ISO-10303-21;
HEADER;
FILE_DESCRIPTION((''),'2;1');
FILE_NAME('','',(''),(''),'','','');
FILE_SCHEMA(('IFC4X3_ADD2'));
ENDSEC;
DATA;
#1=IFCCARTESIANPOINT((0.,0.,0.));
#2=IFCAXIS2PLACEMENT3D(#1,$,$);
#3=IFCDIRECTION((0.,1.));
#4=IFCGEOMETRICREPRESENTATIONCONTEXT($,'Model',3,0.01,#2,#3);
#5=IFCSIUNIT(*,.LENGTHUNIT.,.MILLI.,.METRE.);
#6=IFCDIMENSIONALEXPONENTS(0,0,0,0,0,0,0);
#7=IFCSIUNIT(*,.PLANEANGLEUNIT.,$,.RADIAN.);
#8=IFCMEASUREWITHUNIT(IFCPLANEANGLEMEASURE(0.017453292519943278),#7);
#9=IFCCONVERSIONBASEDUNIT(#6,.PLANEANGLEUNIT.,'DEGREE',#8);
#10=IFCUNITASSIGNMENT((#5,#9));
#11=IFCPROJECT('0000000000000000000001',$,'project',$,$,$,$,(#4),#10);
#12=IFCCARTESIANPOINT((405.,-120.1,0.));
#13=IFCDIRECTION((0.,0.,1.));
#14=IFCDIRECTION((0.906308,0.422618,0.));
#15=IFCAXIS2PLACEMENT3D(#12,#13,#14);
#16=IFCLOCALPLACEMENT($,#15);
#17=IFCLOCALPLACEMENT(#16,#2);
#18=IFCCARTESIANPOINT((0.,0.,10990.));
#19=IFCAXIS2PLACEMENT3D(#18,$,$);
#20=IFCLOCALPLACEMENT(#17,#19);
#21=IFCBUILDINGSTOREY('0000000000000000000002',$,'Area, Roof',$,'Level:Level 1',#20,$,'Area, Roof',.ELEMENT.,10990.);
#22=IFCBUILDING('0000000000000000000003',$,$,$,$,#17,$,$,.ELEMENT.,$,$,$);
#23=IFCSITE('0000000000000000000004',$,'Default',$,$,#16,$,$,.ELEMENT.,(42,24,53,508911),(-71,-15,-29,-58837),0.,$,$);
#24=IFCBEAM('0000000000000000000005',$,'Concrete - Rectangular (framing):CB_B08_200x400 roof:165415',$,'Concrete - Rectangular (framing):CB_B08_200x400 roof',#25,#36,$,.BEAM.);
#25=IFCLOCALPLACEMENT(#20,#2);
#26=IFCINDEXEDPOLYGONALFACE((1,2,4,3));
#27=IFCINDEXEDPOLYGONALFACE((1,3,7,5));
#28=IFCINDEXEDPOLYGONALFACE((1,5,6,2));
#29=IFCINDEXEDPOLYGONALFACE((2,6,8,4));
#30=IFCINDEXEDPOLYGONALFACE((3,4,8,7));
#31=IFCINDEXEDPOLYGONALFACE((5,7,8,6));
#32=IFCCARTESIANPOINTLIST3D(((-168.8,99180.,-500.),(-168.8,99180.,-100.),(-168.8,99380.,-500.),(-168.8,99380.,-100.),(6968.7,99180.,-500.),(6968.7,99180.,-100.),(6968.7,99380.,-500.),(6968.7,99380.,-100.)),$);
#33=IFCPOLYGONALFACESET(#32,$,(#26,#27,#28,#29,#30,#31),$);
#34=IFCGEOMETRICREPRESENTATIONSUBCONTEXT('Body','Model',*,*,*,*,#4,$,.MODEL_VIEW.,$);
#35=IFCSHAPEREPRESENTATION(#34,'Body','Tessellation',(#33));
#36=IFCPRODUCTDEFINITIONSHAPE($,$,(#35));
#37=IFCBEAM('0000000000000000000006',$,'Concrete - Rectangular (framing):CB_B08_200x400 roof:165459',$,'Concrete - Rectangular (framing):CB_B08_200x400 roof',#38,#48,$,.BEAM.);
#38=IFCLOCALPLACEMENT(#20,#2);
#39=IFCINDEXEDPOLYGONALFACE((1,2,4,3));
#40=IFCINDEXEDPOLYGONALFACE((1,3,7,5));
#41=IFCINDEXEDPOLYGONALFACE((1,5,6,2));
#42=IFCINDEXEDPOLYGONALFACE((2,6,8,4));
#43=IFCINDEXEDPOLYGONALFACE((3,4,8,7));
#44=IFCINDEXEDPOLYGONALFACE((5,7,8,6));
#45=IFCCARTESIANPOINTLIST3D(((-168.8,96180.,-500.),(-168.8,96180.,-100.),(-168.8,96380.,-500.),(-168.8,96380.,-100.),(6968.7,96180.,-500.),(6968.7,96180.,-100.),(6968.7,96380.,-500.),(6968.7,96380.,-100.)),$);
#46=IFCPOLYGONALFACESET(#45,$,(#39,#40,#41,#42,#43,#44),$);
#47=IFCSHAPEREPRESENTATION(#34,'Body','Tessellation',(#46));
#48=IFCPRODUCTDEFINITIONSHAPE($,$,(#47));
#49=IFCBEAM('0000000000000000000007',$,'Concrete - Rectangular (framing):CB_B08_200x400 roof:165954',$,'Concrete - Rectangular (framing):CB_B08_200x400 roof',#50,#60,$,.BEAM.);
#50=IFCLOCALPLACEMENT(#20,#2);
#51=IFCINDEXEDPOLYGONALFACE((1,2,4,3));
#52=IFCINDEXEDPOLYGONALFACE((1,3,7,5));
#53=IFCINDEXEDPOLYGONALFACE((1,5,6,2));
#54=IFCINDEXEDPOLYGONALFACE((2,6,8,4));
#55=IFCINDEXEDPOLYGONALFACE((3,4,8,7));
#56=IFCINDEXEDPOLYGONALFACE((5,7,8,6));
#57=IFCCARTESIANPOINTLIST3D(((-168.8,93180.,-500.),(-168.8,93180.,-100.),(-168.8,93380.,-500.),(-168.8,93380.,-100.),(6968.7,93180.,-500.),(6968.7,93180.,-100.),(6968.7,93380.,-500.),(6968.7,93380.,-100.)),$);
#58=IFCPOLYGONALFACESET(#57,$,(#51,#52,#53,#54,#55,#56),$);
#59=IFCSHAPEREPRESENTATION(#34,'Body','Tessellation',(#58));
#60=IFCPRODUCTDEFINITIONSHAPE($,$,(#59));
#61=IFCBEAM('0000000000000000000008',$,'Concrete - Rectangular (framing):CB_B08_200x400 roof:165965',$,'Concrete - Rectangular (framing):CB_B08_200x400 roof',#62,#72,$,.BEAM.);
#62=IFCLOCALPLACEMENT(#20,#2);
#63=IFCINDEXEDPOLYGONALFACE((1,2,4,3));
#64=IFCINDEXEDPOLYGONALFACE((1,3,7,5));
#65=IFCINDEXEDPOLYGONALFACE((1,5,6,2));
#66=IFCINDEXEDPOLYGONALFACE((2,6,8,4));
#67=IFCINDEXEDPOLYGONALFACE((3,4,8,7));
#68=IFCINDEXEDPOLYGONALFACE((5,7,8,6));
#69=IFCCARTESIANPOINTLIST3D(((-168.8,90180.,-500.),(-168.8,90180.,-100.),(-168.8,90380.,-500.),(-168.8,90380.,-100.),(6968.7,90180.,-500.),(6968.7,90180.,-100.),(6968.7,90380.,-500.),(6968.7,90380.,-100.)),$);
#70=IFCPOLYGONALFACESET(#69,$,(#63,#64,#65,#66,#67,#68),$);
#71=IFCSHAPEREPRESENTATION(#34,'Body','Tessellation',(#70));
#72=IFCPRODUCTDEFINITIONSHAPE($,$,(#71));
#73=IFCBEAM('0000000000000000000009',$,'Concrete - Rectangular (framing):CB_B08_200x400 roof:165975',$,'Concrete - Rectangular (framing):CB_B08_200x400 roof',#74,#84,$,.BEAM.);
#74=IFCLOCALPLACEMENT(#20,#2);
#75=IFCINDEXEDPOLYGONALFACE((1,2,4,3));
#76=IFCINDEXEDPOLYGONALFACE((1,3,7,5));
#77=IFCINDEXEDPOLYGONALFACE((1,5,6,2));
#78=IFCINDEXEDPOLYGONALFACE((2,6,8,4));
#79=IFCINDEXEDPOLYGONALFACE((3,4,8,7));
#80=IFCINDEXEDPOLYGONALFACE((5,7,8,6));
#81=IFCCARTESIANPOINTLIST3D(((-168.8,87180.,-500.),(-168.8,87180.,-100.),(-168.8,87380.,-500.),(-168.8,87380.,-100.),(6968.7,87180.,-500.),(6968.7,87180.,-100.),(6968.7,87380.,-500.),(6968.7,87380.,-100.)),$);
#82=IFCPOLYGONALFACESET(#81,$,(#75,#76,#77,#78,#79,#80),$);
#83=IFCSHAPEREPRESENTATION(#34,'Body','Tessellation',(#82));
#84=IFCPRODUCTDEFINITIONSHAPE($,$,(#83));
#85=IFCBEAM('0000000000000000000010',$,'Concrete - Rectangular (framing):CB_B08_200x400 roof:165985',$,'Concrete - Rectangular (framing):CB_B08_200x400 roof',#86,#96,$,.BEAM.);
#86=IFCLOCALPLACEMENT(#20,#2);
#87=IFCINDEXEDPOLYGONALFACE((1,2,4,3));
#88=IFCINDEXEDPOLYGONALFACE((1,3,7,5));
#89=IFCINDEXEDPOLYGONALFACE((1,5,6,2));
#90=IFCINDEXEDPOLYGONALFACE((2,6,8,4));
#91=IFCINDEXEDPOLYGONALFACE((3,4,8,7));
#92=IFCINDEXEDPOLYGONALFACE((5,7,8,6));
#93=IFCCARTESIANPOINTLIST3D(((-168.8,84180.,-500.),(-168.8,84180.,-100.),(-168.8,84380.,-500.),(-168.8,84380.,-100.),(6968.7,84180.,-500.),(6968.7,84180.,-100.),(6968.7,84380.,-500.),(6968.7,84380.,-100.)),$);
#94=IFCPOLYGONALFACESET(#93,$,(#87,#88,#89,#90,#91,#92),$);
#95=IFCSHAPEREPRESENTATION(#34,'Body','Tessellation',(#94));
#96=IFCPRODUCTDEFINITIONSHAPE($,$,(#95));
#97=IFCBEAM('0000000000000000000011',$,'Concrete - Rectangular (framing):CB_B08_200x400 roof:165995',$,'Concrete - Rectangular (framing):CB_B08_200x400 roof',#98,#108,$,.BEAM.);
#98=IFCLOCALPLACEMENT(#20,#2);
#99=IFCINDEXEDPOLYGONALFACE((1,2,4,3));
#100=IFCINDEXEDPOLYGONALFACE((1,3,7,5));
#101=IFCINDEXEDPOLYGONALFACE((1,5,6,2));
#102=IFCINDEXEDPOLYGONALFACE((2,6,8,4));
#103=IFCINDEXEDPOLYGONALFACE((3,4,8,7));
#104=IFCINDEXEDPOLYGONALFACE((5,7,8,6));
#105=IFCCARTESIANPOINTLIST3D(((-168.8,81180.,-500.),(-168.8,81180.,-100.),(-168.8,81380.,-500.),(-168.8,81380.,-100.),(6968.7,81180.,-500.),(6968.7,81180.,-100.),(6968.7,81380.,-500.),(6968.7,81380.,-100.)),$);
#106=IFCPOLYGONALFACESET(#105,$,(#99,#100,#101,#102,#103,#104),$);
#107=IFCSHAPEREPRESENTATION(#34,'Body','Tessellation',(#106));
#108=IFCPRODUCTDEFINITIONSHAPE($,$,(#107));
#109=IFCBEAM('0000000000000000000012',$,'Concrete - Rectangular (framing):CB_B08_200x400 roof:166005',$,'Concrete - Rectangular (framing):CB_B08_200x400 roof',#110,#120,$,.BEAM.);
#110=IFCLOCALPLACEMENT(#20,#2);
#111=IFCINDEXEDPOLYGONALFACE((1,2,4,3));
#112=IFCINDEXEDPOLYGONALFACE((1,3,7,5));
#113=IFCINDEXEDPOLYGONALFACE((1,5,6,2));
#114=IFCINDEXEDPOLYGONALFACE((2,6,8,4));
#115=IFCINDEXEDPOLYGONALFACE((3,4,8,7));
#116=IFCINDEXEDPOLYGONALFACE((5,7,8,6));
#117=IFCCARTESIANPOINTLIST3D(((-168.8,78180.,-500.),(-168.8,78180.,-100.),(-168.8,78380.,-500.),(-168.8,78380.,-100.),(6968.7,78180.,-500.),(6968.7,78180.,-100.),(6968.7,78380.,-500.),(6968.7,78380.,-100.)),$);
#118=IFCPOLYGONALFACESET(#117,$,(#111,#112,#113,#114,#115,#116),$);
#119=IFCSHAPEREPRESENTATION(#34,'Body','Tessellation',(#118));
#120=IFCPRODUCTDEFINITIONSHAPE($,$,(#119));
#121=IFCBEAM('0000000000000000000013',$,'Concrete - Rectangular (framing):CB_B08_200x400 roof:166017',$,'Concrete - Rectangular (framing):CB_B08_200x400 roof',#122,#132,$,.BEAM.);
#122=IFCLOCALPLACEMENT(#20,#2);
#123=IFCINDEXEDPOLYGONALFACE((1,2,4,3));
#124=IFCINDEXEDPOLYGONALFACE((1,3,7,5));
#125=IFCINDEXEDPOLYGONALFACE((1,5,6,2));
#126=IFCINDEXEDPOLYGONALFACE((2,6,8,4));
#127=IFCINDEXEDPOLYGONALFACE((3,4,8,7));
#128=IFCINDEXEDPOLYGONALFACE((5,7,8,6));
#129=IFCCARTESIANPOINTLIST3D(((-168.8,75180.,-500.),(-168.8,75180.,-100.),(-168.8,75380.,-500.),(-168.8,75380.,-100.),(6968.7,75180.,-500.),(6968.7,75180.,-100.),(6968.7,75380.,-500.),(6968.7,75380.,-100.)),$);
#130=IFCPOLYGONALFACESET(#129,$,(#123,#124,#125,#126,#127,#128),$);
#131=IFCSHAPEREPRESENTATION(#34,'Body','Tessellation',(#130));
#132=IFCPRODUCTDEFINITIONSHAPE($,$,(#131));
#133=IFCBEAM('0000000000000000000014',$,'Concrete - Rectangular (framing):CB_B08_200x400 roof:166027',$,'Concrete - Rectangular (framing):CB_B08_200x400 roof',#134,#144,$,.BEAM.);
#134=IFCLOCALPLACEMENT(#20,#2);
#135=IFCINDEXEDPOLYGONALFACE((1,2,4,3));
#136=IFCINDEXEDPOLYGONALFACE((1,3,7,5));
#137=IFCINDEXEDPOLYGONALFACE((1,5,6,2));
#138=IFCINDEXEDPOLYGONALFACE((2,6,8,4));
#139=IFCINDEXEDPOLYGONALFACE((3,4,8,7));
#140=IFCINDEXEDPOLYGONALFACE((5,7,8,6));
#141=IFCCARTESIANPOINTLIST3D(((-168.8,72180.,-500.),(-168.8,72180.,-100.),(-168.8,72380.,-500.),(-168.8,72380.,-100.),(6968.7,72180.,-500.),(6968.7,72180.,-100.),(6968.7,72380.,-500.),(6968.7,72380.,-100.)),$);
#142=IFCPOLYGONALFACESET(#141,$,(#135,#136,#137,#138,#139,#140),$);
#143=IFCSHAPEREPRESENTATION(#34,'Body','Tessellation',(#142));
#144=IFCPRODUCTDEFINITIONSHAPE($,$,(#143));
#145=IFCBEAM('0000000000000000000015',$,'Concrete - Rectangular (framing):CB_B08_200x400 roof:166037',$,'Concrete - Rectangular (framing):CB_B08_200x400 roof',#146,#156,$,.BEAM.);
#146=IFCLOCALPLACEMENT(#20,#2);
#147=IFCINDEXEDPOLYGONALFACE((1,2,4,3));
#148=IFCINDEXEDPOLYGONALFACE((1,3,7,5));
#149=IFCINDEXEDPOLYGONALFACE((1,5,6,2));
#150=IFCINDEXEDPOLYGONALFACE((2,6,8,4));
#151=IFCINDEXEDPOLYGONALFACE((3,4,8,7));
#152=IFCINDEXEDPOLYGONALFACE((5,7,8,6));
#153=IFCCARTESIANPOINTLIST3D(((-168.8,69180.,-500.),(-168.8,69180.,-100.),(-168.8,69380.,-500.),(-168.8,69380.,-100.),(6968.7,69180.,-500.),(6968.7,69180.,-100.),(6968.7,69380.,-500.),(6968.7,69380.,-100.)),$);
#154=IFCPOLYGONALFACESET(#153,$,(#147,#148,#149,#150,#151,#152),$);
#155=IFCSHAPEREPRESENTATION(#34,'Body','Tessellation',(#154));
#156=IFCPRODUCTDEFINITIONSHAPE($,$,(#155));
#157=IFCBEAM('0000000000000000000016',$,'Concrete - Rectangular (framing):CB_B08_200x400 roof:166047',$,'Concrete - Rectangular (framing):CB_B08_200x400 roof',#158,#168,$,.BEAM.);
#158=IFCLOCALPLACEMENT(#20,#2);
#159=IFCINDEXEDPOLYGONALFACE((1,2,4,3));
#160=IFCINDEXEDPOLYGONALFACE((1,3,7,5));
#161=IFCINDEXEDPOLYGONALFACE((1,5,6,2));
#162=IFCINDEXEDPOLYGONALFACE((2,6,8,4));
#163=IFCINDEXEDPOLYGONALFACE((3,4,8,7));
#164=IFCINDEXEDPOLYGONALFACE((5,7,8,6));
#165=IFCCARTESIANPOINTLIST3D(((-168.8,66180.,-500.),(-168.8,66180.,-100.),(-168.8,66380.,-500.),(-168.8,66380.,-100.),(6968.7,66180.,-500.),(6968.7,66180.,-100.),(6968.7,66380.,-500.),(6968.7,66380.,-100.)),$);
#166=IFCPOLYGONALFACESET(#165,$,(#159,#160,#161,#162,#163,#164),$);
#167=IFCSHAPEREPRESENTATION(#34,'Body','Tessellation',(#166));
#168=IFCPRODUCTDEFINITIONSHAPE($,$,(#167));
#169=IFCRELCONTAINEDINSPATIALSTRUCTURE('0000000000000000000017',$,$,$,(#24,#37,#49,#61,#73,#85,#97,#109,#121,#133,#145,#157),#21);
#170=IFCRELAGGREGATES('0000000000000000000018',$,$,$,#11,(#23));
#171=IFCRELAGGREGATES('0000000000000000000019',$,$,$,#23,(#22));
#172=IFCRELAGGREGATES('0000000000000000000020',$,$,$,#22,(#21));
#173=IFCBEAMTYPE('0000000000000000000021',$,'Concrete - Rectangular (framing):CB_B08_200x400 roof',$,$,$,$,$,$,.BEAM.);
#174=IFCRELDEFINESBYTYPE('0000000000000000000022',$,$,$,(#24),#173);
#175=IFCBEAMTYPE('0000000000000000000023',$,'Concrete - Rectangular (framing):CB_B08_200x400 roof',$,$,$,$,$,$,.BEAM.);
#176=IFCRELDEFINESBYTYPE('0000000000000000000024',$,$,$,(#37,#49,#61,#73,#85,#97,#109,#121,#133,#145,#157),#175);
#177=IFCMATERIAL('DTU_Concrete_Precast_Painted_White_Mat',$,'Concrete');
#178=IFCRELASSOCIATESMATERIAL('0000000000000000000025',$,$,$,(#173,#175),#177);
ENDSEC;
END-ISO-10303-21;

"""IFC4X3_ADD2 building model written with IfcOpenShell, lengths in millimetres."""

from ifc_helpers import new_model, entity, si_unit, converted_unit, direction, frame, origin, origin_2d_with_axis, place, context, subcontext, project, spatial, rectangle, extrude, source, transform, mapped, material, material_profile, profile_set, type_object, type_shapes, element, save


model = new_model("IFC4X3_ADD2")

# Units and contexts
model_context = context("Model", 3, precision=0.01, world=origin(), true_north=direction((0.0, 1.0)))
body_context = subcontext(model_context, "Body", "Model", "MODEL_VIEW")
ifc_project = project(units=[si_unit("LENGTHUNIT", "METRE", prefix="MILLI"), converted_unit("PLANEANGLEUNIT", "DEGREE", entity("IfcPlaneAngleMeasure", 0.017453292519943278), si_unit("PLANEANGLEUNIT", "RADIAN"), dimensions=[0, 0, 0, 0, 0, 0, 0])], contexts=[model_context])

# Site, building, storey
site_placement = place(None, frame((405.0, -120.1, 0.0), z_axis=(0.0, 0.0, 1.0), x_axis=(0.906308, 0.422618, 0.0)))
site = spatial("IfcSite", under=ifc_project, at=site_placement, Name="Default", CompositionType="ELEMENT", RefLatitude=(42, 24, 53, 508911), RefLongitude=(-71, -15, -29, -58837), RefElevation=0.0)
building_placement = place(site_placement, origin())
building = spatial("IfcBuilding", under=site, at=building_placement, CompositionType="ELEMENT")
storey_placement = place(building_placement, frame((0.0, 0.0, 10990.0)))
storey = spatial("IfcBuildingStorey", under=building, at=storey_placement, Name="Area, Roof", ObjectType="Level:Level 1", LongName="Area, Roof", CompositionType="ELEMENT", Elevation=10990.0)

# Beams
ifc_material = material(Name="DTU_Concrete_Precast_Painted_White_Mat", Category="Concrete")
ifc_material_profile = material_profile(ifc_material, rectangle(XDim=7137.5, YDim=200.0, at=origin_2d_with_axis()), Name="CB_B08_200x400 roof")
ifc_profile_set = profile_set([ifc_material_profile], Name="CB_B08_200x400 roof")
beam_type_1 = type_object("IfcBeamType", Name="Concrete - Rectangular (framing):CB_B08_200x400 roof", PredefinedType="BEAM", material=ifc_profile_set)
shared_shape_1 = source(origin(), body_context, "Body", "SweptSolid", [
    extrude(rectangle(XDim=7137.5, YDim=200.0, at=origin_2d_with_axis()), frame((6.3, 0.0, -200.0), z_axis=(0.0, 0.0, 1.0), x_axis=(-1.0, 0.0, 0.0)), (0.0, 0.0, 1.0), 400.0),
])
type_shapes(beam_type_1, [shared_shape_1])
beam_placement = place(storey_placement, frame((3406.2, 99280.0, -300.0), z_axis=(0.0, 0.0, 1.0), x_axis=(-1.0, 0.0, 0.0)))
element("IfcBeam", 1, at=beam_placement, inside=storey, type_object=beam_type_1, Name="Concrete - Rectangular (framing):CB_B08_200x400 roof:165415", ObjectType="Concrete - Rectangular (framing):CB_B08_200x400 roof", PredefinedType="BEAM", context=body_context, shape_type="MappedRepresentation", body=[
    mapped(shared_shape_1, transform((0.0, 0.0, 0.0), scale=1.0)),
])
beam_type_2 = type_object("IfcBeamType", Name="Concrete - Rectangular (framing):CB_B08_200x400 roof", PredefinedType="BEAM", material=ifc_profile_set)
shared_shape_2 = source(origin(), body_context, "Body", "SweptSolid", [
    extrude(rectangle(XDim=7137.5, YDim=200.0, at=origin_2d_with_axis()), frame((6.3, 0.0, -200.0), z_axis=(0.0, 0.0, 1.0), x_axis=(-1.0, 0.0, 0.0)), (0.0, 0.0, 1.0), 400.0),
])
type_shapes(beam_type_2, [shared_shape_2])
for number, where, z_axis, x_axis, name in (
    (2, (3406.2, 96280.0, -300.0), (0.0, 0.0, 1.0), (-1.0, 0.0, 0.0), "Concrete - Rectangular (framing):CB_B08_200x400 roof:165459"),
    (3, (3406.2, 93280.0, -300.0), (0.0, 0.0, 1.0), (-1.0, 0.0, 0.0), "Concrete - Rectangular (framing):CB_B08_200x400 roof:165954"),
    (4, (3406.2, 90280.0, -300.0), (0.0, 0.0, 1.0), (-1.0, 0.0, 0.0), "Concrete - Rectangular (framing):CB_B08_200x400 roof:165965"),
    (5, (3406.2, 87280.0, -300.0), (0.0, 0.0, 1.0), (-1.0, 0.0, 0.0), "Concrete - Rectangular (framing):CB_B08_200x400 roof:165975"),
    (6, (3406.2, 84280.0, -300.0), (0.0, 0.0, 1.0), (-1.0, 0.0, 0.0), "Concrete - Rectangular (framing):CB_B08_200x400 roof:165985"),
    (7, (3406.2, 81280.0, -300.0), (0.0, 0.0, 1.0), (-1.0, 0.0, 0.0), "Concrete - Rectangular (framing):CB_B08_200x400 roof:165995"),
    (8, (3406.2, 78280.0, -300.0), (0.0, 0.0, 1.0), (-1.0, 0.0, 0.0), "Concrete - Rectangular (framing):CB_B08_200x400 roof:166005"),
    (9, (3406.2, 75280.0, -300.0), (0.0, 0.0, 1.0), (-1.0, 0.0, 0.0), "Concrete - Rectangular (framing):CB_B08_200x400 roof:166017"),
    (10, (3406.2, 72280.0, -300.0), (0.0, 0.0, 1.0), (-1.0, 0.0, 0.0), "Concrete - Rectangular (framing):CB_B08_200x400 roof:166027"),
    (11, (3406.2, 69280.0, -300.0), (0.0, 0.0, 1.0), (-1.0, 0.0, 0.0), "Concrete - Rectangular (framing):CB_B08_200x400 roof:166037"),
    (12, (3406.2, 66280.0, -300.0), (0.0, 0.0, 1.0), (-1.0, 0.0, 0.0), "Concrete - Rectangular (framing):CB_B08_200x400 roof:166047"),
):
    element("IfcBeam", number, at=place(storey_placement, frame(where, z_axis=z_axis, x_axis=x_axis)), inside=storey, type_object=beam_type_2, Name=name, ObjectType="Concrete - Rectangular (framing):CB_B08_200x400 roof", PredefinedType="BEAM", context=body_context, shape_type="MappedRepresentation", body=[
        mapped(shared_shape_2, transform((0.0, 0.0, 0.0), scale=1.0)),
    ])

save(model, "model.ifc")
